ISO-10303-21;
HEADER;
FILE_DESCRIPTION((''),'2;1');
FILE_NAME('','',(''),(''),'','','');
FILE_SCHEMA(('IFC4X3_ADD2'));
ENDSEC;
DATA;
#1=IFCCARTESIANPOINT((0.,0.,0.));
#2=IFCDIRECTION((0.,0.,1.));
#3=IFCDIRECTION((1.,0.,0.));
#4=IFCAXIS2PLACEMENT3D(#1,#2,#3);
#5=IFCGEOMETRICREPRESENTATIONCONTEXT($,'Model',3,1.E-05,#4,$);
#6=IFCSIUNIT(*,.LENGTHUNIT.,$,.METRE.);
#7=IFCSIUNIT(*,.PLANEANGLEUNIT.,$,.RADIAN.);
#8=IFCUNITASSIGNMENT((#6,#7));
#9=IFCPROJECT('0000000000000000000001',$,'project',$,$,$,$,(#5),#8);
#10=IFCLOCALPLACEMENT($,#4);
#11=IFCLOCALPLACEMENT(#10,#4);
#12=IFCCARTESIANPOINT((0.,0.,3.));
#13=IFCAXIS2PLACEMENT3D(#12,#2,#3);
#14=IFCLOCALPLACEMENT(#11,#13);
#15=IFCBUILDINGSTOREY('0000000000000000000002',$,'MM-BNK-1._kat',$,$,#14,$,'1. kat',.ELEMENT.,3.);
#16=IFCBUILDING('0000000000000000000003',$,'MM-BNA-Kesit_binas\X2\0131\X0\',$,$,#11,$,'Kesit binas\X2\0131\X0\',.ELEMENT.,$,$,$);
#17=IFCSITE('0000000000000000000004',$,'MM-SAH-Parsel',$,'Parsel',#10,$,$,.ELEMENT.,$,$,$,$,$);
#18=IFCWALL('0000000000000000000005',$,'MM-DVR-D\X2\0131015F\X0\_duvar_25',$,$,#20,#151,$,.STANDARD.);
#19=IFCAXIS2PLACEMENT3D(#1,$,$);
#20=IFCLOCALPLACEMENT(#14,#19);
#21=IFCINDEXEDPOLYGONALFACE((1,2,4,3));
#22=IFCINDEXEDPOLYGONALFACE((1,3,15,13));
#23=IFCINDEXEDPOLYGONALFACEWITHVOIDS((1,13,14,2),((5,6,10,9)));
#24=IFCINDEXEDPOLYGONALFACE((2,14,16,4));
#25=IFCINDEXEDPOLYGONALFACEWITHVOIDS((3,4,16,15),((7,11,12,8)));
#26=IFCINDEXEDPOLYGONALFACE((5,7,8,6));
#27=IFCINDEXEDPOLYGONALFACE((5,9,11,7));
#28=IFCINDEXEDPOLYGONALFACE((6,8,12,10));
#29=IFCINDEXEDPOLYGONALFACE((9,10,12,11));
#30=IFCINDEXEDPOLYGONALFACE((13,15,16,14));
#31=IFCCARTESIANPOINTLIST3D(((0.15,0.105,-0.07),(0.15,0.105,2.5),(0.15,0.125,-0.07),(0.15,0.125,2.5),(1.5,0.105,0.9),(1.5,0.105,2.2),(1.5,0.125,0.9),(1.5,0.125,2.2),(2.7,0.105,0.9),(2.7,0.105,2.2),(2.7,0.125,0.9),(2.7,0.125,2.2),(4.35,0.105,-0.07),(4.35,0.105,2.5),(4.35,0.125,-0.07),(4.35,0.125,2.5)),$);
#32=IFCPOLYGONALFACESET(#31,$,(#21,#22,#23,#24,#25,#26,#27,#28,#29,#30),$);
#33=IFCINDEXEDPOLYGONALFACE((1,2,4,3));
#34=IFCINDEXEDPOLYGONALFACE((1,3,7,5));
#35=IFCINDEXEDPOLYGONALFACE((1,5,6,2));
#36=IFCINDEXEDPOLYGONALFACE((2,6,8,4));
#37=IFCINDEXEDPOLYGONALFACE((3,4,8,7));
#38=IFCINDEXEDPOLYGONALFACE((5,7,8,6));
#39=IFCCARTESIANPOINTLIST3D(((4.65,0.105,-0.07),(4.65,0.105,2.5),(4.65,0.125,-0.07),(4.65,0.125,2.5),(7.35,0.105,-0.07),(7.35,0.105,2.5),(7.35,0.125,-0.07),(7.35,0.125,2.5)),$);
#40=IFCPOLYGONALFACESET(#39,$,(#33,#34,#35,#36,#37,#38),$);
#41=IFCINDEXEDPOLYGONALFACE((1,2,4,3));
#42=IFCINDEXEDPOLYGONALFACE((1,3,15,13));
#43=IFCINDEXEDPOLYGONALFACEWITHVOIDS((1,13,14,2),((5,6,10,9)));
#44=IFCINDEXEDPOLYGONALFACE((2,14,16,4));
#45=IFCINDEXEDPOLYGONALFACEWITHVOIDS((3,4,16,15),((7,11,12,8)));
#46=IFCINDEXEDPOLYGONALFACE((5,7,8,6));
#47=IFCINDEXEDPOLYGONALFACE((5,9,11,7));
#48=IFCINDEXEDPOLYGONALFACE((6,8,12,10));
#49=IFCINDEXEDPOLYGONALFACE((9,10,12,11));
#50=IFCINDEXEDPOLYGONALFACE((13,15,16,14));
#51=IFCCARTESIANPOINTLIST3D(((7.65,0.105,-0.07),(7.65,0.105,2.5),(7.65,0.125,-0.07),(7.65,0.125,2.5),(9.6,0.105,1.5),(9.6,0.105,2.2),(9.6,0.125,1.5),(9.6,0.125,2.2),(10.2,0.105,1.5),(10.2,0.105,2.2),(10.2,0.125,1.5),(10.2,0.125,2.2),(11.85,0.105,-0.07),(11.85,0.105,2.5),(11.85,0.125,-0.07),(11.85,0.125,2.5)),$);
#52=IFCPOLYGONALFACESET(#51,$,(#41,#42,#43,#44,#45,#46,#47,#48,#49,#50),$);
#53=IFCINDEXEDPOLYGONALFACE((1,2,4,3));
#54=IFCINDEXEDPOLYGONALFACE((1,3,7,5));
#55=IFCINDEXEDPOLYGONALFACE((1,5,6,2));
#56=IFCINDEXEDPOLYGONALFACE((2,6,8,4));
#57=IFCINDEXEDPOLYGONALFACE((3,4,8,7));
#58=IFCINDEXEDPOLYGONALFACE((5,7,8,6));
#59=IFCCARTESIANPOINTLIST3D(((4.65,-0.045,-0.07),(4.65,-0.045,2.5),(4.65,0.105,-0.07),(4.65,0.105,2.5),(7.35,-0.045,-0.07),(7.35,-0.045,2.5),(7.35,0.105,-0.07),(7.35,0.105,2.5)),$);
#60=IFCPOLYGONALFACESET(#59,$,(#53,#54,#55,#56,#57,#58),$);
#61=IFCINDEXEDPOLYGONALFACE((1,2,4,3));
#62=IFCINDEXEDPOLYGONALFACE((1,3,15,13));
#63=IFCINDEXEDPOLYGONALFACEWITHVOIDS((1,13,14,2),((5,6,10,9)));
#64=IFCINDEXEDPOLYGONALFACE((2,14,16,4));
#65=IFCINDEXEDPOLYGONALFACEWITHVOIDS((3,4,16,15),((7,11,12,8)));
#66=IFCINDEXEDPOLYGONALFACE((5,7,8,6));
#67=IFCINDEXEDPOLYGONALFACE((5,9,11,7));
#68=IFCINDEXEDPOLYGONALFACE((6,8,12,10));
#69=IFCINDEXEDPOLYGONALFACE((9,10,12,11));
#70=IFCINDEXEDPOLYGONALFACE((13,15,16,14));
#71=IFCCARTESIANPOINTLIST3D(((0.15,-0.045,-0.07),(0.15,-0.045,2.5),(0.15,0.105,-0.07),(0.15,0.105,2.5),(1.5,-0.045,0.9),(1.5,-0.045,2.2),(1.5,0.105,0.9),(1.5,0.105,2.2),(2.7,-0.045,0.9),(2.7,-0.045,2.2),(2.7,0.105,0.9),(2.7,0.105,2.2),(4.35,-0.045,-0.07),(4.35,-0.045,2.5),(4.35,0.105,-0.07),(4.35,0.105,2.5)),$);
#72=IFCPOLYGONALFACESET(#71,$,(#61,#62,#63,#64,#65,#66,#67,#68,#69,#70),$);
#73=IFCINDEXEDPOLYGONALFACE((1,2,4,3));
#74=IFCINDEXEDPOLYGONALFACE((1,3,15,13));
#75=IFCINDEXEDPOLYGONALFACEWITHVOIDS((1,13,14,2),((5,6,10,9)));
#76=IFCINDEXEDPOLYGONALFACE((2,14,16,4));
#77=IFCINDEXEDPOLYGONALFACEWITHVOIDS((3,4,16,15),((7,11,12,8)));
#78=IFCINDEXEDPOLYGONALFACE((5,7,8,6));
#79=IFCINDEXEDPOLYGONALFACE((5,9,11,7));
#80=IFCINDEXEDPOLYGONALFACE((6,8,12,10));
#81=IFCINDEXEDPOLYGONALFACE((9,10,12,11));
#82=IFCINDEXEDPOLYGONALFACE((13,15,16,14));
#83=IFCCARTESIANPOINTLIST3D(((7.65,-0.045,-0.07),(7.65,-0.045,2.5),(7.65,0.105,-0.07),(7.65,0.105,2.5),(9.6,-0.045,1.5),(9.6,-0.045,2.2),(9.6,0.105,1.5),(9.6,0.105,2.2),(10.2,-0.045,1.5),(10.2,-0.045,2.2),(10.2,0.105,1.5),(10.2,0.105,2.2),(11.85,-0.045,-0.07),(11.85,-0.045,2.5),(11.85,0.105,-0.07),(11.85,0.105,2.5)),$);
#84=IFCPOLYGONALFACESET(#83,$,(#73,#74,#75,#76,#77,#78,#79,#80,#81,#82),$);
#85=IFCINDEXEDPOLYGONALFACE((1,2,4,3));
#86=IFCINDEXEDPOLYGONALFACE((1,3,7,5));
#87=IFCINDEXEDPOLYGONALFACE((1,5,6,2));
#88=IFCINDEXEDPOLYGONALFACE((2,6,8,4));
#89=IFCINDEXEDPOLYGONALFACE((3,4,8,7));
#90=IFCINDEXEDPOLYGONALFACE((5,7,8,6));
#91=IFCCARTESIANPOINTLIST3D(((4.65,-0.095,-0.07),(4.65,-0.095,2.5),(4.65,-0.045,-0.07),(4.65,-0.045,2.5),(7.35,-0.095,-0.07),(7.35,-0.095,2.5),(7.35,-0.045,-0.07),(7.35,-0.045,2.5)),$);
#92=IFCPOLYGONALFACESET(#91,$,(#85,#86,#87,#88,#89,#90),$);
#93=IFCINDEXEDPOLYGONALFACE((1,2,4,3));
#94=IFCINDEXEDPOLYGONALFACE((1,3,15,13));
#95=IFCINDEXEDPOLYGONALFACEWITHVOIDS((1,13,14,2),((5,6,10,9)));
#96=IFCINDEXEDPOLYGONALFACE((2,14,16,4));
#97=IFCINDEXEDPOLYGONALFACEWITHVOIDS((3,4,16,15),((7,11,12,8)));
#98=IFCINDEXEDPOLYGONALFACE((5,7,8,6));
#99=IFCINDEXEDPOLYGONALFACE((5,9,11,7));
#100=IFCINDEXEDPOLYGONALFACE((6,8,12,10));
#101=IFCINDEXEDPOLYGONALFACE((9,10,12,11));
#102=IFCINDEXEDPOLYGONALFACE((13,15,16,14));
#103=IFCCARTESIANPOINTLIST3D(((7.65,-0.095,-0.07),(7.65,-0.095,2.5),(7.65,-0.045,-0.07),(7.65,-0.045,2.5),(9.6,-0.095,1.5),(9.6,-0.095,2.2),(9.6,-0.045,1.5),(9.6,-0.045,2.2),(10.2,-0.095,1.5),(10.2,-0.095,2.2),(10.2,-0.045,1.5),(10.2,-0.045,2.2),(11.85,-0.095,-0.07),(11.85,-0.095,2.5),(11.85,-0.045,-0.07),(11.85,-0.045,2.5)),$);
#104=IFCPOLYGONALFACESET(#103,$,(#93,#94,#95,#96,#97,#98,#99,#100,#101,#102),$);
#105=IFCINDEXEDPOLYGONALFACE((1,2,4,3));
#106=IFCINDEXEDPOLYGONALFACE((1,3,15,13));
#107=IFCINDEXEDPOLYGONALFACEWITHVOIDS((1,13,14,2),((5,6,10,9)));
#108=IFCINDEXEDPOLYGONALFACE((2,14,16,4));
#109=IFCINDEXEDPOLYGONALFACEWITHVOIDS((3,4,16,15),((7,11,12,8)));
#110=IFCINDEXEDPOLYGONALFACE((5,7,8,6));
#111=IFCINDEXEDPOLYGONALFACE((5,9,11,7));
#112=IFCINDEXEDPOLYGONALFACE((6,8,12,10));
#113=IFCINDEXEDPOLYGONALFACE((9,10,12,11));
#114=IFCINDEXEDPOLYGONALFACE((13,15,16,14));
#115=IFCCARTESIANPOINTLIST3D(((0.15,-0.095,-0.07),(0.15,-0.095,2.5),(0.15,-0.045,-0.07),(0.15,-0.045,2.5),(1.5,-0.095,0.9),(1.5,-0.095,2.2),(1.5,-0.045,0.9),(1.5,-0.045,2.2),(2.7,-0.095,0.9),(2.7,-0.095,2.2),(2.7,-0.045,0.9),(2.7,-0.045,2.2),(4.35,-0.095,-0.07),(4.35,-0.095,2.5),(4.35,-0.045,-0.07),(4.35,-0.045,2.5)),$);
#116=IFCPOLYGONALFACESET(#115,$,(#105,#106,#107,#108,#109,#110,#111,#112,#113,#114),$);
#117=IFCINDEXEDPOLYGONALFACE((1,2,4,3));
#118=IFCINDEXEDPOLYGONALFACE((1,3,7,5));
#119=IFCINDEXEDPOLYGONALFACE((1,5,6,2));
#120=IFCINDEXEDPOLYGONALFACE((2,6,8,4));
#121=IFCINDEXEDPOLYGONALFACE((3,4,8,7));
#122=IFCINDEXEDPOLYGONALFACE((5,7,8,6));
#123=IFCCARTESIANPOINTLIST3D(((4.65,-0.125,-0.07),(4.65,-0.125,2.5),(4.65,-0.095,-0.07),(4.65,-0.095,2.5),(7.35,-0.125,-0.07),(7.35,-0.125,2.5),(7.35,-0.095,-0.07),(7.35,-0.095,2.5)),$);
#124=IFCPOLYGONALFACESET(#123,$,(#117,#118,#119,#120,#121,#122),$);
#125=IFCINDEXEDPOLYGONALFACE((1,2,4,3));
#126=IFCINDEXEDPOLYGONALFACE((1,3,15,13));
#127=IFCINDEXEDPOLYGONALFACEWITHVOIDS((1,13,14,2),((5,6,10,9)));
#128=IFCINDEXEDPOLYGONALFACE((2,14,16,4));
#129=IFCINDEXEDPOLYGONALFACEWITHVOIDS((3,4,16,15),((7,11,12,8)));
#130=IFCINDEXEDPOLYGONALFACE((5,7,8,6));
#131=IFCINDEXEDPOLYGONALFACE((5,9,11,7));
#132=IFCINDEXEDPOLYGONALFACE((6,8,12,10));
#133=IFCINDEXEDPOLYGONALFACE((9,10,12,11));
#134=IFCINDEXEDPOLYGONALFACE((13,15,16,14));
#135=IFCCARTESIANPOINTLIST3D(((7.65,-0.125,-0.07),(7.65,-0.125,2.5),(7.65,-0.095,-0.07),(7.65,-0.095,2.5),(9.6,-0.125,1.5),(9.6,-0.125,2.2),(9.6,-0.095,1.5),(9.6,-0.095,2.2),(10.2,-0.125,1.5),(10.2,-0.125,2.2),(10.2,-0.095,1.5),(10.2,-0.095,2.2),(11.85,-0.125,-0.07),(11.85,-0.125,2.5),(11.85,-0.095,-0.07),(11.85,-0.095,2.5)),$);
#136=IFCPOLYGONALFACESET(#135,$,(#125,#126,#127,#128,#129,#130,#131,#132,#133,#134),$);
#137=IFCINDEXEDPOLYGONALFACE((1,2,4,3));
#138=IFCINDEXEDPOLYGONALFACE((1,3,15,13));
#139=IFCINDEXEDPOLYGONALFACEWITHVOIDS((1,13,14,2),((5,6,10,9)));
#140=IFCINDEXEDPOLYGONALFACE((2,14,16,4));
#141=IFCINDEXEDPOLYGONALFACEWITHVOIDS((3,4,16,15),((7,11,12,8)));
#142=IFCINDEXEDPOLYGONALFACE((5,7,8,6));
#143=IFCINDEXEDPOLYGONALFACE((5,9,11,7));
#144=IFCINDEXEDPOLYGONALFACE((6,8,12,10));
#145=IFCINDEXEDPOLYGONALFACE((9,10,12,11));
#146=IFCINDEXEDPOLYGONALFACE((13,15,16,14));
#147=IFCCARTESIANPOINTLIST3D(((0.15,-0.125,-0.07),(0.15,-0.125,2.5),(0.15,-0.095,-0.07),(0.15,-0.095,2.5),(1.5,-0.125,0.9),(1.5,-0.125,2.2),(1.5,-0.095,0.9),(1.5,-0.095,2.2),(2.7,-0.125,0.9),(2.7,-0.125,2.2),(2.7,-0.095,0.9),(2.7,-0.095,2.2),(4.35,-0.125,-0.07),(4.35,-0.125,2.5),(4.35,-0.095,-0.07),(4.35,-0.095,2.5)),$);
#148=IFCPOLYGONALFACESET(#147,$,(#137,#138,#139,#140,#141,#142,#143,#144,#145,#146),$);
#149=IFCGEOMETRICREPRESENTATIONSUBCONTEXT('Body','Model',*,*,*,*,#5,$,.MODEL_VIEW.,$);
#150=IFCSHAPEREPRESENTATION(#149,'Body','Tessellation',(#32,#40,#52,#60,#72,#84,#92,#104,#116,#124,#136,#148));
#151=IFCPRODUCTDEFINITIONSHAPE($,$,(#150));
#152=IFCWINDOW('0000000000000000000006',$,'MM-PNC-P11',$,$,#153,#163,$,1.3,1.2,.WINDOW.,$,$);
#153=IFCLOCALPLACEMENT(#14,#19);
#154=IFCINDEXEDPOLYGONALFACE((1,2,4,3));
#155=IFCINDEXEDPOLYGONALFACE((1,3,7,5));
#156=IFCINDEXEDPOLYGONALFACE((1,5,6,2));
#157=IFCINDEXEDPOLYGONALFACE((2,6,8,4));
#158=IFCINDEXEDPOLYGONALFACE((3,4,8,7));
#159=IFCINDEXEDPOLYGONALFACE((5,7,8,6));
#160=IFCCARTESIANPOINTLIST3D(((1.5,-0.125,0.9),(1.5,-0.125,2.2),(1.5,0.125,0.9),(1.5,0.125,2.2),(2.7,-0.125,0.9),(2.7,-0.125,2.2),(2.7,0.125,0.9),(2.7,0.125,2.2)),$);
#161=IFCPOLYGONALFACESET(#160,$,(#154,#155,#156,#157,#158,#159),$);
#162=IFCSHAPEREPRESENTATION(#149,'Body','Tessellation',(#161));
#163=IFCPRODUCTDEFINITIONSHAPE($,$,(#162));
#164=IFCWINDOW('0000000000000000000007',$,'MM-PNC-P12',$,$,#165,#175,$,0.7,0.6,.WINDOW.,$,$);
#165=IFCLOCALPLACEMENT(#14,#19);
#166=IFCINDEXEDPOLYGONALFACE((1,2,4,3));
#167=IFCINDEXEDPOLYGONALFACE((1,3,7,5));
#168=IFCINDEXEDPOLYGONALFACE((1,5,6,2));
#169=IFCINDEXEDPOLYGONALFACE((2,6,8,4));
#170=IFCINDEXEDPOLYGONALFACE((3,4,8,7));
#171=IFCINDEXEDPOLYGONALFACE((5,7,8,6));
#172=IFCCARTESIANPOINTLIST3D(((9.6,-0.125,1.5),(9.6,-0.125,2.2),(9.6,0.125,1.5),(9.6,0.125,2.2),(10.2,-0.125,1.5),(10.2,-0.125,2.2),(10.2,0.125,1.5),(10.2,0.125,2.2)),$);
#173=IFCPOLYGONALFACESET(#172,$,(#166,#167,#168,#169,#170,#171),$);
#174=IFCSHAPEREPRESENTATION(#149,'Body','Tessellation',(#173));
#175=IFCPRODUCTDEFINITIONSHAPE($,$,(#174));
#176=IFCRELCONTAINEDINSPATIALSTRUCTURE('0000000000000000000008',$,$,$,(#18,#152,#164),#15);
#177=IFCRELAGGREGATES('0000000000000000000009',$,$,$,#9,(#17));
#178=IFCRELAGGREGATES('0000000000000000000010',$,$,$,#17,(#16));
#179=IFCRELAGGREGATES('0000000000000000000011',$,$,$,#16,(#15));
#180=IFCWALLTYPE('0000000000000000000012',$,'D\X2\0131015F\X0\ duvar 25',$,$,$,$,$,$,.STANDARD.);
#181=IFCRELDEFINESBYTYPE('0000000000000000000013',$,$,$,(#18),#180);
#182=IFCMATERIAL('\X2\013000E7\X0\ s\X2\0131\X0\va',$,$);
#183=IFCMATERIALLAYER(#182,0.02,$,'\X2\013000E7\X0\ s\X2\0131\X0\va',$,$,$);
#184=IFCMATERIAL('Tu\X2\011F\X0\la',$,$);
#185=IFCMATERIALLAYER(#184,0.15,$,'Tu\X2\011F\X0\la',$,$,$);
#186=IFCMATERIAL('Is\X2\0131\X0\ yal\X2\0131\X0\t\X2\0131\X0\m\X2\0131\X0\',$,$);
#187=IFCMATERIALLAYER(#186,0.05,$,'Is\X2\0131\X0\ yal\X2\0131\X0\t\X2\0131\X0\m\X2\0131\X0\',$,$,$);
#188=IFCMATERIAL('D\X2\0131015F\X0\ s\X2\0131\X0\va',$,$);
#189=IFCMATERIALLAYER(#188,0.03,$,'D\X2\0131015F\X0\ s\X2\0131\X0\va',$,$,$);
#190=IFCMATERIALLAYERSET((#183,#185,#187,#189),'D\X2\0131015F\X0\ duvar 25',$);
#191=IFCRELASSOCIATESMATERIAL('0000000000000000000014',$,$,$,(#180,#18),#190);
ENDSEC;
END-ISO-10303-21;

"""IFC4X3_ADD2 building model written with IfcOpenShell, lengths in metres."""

from ifc_helpers import new_model, si_unit, frame, origin_with_axes, place, context, subcontext, project, spatial, polyline, outline, extrude, material, layer, layer_set, type_object, element, fill, save


model = new_model("IFC4X3_ADD2")

# Units and contexts
model_context = context("Model", 3, precision=1e-05, world=origin_with_axes())
body_context = subcontext(model_context, "Body", "Model", "MODEL_VIEW")
ifc_project = project(units=[si_unit("LENGTHUNIT", "METRE"), si_unit("PLANEANGLEUNIT", "RADIAN")], contexts=[model_context])

# Site, building, storey
site_placement = place(None, origin_with_axes())
site = spatial("IfcSite", under=ifc_project, at=site_placement, Name="MM-SAH-Parsel", ObjectType="Parsel", CompositionType="ELEMENT")
building_placement = place(site_placement, origin_with_axes())
building = spatial("IfcBuilding", under=site, at=building_placement, Name="MM-BNA-Kesit_binası", LongName="Kesit binası", CompositionType="ELEMENT")
storey_placement = place(building_placement, frame((0.0, 0.0, 3.0), z_axis=(0.0, 0.0, 1.0), x_axis=(1.0, 0.0, 0.0)))
storey = spatial("IfcBuildingStorey", under=building, at=storey_placement, Name="MM-BNK-1._kat", LongName="1. kat", CompositionType="ELEMENT", Elevation=3.0)

# Wall, openings, windows
ifc_material_1 = material(Name="İç sıva")
ifc_layer_1 = layer(ifc_material_1, 0.02, Name="İç sıva")
ifc_material_2 = material(Name="Tuğla")
ifc_layer_2 = layer(ifc_material_2, 0.15, Name="Tuğla")
ifc_material_3 = material(Name="Isı yalıtımı")
ifc_layer_3 = layer(ifc_material_3, 0.05, Name="Isı yalıtımı")
ifc_material_4 = material(Name="Dış sıva")
ifc_layer_4 = layer(ifc_material_4, 0.03, Name="Dış sıva")
ifc_layer_set_1 = layer_set([ifc_layer_1, ifc_layer_2, ifc_layer_3, ifc_layer_4], Name="Dış duvar 25")
wall_type_1 = type_object("IfcWallType", Name="Dış duvar 25", PredefinedType="STANDARD", material=ifc_layer_set_1)
wall_1_placement = place(storey_placement, origin_with_axes())
wall_1 = element("IfcWall", 1, at=wall_1_placement, inside=storey, type_object=wall_type_1, material=ifc_layer_set_1, Name="MM-DVR-Dış_duvar_25", PredefinedType="STANDARD", context=body_context, shape_type="SweptSolid", body=[
    extrude(outline(polyline([(0.15, 0.105), (4.35, 0.105), (4.35, 0.125), (0.15, 0.125), (0.15, 0.105)])), frame((0.0, 0.0, -0.07)), (0.0, 0.0, 1.0), 2.57),
    extrude(outline(polyline([(4.65, 0.105), (7.35, 0.105), (7.35, 0.125), (4.65, 0.125), (4.65, 0.105)])), frame((0.0, 0.0, -0.07)), (0.0, 0.0, 1.0), 2.57),
    extrude(outline(polyline([(7.65, 0.105), (11.85, 0.105), (11.85, 0.125), (7.65, 0.125), (7.65, 0.105)])), frame((0.0, 0.0, -0.07)), (0.0, 0.0, 1.0), 2.57),
    extrude(outline(polyline([(4.65, -0.045), (7.35, -0.045), (7.35, 0.105), (4.65, 0.105), (4.65, -0.045)])), frame((0.0, 0.0, -0.07)), (0.0, 0.0, 1.0), 2.57),
    extrude(outline(polyline([(0.15, -0.045), (4.35, -0.045), (4.35, 0.105), (0.15, 0.105), (0.15, -0.045)])), frame((0.0, 0.0, -0.07)), (0.0, 0.0, 1.0), 2.57),
    extrude(outline(polyline([(7.65, -0.045), (11.85, -0.045), (11.85, 0.105), (7.65, 0.105), (7.65, -0.045)])), frame((0.0, 0.0, -0.07)), (0.0, 0.0, 1.0), 2.57),
    extrude(outline(polyline([(4.65, -0.095), (7.35, -0.095), (7.35, -0.045), (4.65, -0.045), (4.65, -0.095)])), frame((0.0, 0.0, -0.07)), (0.0, 0.0, 1.0), 2.57),
    extrude(outline(polyline([(7.65, -0.095), (11.85, -0.095), (11.85, -0.045), (7.65, -0.045), (7.65, -0.095)])), frame((0.0, 0.0, -0.07)), (0.0, 0.0, 1.0), 2.57),
    extrude(outline(polyline([(0.15, -0.095), (4.35, -0.095), (4.35, -0.045), (0.15, -0.045), (0.15, -0.095)])), frame((0.0, 0.0, -0.07)), (0.0, 0.0, 1.0), 2.57),
    extrude(outline(polyline([(4.65, -0.125), (7.35, -0.125), (7.35, -0.095), (4.65, -0.095), (4.65, -0.125)])), frame((0.0, 0.0, -0.07)), (0.0, 0.0, 1.0), 2.57),
    extrude(outline(polyline([(7.65, -0.125), (11.85, -0.125), (11.85, -0.095), (7.65, -0.095), (7.65, -0.125)])), frame((0.0, 0.0, -0.07)), (0.0, 0.0, 1.0), 2.57),
    extrude(outline(polyline([(0.15, -0.125), (4.35, -0.125), (4.35, -0.095), (0.15, -0.095), (0.15, -0.125)])), frame((0.0, 0.0, -0.07)), (0.0, 0.0, 1.0), 2.57),
])
opening_1_placement = place(storey_placement, origin_with_axes())
opening_1 = element("IfcOpeningElement", 2, at=opening_1_placement, cuts=wall_1, PredefinedType="OPENING", context=body_context, shape_type="SweptSolid", body=[
    extrude(outline(polyline([(1.5, 0.125), (2.7, 0.125), (2.7, -0.125), (1.5, -0.125), (1.5, 0.125)])), frame((0.0, 0.0, 0.9)), (0.0, 0.0, 1.0), 1.3),
])
opening_2_placement = place(storey_placement, origin_with_axes())
opening_2 = element("IfcOpeningElement", 3, at=opening_2_placement, cuts=wall_1, PredefinedType="OPENING", context=body_context, shape_type="SweptSolid", body=[
    extrude(outline(polyline([(9.6, 0.125), (10.2, 0.125), (10.2, -0.125), (9.6, -0.125), (9.6, 0.125)])), frame((0.0, 0.0, 1.5)), (0.0, 0.0, 1.0), 0.7),
])
window_1_placement = place(storey_placement, origin_with_axes())
window_1 = element("IfcWindow", 4, at=window_1_placement, inside=storey, Name="MM-PNC-P11", OverallHeight=1.3, OverallWidth=1.2, PredefinedType="WINDOW", context=body_context, shape_type="SweptSolid", body=[
    extrude(outline(polyline([(1.5, 0.125), (2.7, 0.125), (2.7, -0.125), (1.5, -0.125), (1.5, 0.125)])), frame((0.0, 0.0, 0.9)), (0.0, 0.0, 1.0), 1.3),
])
fill(opening_1, window_1)
window_2_placement = place(storey_placement, origin_with_axes())
window_2 = element("IfcWindow", 5, at=window_2_placement, inside=storey, Name="MM-PNC-P12", OverallHeight=0.7, OverallWidth=0.6, PredefinedType="WINDOW", context=body_context, shape_type="SweptSolid", body=[
    extrude(outline(polyline([(9.6, 0.125), (10.2, 0.125), (10.2, -0.125), (9.6, -0.125), (9.6, 0.125)])), frame((0.0, 0.0, 1.5)), (0.0, 0.0, 1.0), 0.7),
])
fill(opening_2, window_2)

save(model, "model.ifc")
